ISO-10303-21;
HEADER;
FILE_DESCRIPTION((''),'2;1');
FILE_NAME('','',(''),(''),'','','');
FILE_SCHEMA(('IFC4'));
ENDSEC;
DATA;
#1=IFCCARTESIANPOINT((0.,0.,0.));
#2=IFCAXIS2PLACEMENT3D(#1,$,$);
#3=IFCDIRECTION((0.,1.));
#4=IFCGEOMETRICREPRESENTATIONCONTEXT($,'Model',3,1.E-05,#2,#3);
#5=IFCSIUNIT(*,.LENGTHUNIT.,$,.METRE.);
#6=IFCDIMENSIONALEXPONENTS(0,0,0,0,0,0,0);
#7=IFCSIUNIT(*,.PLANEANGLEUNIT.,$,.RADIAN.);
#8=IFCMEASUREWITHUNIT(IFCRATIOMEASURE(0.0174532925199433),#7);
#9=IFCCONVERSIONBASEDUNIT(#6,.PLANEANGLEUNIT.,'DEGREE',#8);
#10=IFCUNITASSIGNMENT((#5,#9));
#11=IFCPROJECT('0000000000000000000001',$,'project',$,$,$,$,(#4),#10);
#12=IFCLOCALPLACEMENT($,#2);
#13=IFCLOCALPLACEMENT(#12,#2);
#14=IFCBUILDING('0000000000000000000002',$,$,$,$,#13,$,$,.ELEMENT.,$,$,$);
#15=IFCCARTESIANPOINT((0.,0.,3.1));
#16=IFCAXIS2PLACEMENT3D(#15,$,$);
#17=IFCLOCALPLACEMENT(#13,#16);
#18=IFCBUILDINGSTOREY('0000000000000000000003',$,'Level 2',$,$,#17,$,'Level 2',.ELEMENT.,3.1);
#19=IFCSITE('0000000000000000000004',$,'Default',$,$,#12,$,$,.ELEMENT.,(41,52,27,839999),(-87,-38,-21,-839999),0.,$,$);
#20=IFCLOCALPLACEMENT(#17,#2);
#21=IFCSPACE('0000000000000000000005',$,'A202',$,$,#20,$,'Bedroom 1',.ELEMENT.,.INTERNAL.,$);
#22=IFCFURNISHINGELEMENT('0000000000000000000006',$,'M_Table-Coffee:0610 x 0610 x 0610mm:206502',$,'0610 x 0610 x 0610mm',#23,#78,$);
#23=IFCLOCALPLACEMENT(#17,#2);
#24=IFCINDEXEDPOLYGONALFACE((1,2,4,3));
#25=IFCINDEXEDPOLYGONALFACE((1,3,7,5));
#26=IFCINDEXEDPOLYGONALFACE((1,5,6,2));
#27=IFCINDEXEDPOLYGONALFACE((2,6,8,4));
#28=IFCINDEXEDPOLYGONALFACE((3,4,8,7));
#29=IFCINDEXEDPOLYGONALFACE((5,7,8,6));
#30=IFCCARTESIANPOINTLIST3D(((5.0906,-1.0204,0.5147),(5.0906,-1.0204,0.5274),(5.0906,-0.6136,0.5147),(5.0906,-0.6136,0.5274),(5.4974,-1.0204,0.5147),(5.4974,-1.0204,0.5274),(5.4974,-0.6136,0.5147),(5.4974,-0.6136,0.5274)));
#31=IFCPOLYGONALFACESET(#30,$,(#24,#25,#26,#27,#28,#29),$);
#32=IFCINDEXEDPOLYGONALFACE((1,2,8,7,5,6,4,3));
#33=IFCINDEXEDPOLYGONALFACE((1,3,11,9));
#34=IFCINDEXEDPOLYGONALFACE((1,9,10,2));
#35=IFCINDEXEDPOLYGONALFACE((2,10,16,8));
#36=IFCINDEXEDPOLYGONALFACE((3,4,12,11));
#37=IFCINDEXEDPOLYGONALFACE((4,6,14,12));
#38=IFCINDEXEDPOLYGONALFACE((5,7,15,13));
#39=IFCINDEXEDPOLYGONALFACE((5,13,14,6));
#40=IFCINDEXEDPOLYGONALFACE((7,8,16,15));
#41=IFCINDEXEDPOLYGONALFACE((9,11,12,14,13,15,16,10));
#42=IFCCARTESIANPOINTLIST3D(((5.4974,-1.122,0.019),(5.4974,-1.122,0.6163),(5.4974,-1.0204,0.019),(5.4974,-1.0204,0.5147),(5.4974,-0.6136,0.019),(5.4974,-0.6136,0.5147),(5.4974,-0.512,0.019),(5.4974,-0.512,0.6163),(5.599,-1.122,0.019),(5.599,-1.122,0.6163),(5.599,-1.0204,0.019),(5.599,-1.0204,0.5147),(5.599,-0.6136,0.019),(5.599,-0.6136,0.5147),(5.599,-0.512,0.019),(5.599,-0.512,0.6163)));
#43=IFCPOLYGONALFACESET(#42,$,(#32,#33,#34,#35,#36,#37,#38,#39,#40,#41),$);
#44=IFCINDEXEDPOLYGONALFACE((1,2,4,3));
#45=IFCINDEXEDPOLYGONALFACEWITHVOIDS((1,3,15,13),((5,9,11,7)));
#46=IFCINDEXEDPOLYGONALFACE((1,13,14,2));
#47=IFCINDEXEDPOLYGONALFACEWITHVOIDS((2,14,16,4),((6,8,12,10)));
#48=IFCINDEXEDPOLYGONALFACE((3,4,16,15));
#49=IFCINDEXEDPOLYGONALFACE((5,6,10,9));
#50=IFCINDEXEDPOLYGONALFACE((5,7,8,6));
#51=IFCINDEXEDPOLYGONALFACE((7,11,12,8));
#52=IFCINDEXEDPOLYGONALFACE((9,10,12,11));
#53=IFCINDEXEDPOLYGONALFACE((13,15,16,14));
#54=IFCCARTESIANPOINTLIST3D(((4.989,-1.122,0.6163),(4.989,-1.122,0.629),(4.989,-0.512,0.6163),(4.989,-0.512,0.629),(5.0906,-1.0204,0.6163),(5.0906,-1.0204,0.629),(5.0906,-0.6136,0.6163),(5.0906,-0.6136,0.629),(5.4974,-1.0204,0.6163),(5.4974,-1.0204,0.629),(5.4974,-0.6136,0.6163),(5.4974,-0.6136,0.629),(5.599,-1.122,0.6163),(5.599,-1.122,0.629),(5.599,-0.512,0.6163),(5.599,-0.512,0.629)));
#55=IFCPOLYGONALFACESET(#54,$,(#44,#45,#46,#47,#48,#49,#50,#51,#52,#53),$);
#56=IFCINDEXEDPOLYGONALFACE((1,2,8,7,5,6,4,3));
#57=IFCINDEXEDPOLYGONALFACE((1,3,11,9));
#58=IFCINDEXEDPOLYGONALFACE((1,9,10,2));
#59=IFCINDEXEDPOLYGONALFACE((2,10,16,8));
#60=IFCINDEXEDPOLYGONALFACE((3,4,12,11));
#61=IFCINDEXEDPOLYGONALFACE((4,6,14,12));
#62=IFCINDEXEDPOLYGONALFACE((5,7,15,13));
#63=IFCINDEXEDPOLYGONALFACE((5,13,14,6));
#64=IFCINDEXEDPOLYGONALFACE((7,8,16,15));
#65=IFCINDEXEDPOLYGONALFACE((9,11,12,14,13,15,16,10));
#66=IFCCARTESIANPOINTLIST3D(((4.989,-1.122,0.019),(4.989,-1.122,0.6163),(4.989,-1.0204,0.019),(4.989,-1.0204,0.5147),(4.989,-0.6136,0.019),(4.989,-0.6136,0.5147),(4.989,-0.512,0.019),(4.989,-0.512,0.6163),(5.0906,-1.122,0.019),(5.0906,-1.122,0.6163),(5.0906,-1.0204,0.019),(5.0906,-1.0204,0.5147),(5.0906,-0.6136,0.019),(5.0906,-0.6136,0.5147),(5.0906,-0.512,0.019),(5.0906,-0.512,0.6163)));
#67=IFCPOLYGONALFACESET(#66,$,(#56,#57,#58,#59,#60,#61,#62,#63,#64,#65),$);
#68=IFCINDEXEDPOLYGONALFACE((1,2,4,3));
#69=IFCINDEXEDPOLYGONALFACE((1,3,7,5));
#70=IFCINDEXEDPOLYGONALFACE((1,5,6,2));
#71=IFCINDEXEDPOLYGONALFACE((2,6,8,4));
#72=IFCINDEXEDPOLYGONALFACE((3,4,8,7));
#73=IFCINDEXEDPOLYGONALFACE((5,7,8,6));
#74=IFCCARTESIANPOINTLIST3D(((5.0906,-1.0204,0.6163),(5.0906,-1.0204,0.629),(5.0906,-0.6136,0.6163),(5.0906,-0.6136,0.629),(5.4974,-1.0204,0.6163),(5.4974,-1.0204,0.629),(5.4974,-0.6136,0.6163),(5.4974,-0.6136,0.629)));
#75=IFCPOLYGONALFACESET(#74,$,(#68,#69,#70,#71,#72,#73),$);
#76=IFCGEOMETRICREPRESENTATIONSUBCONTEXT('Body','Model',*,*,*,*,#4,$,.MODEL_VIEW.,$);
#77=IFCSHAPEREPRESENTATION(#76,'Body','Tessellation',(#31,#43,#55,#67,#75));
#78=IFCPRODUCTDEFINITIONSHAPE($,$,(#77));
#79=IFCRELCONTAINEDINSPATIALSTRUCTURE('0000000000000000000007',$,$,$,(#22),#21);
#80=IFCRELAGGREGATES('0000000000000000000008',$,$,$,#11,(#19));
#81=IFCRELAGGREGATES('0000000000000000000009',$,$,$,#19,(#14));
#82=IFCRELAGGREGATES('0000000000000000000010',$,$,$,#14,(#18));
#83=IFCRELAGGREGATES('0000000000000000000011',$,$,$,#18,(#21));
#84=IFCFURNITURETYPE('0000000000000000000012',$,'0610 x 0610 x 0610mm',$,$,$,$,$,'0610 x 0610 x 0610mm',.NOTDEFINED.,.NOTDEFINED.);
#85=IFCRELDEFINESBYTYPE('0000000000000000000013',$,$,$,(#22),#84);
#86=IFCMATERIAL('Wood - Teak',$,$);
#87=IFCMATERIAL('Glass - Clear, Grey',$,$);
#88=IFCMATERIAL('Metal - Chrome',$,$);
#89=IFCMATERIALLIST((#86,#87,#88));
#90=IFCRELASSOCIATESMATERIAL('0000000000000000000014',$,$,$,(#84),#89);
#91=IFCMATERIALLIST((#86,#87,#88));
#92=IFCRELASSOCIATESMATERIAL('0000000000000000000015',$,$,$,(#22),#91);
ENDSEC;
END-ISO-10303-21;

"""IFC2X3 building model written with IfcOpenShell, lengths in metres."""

from ifc_helpers import new_model, entity, si_unit, converted_unit, direction, frame, origin, origin_2d_with_axis, place, context, subcontext, project, spatial, polyline, rectangle, outline, extrude, source, transform, mapped, material, material_list, type_object, type_shapes, element, save


model = new_model("IFC2X3")

# Units and contexts
model_context = context("Model", 3, precision=1e-05, world=origin(), true_north=direction((0.0, 1.0)))
body_context = subcontext(model_context, "Body", "Model", "MODEL_VIEW")
ifc_project = project(units=[si_unit("LENGTHUNIT", "METRE"), converted_unit("PLANEANGLEUNIT", "DEGREE", entity("IfcRatioMeasure", 0.0174532925199433), si_unit("PLANEANGLEUNIT", "RADIAN"), dimensions=[0, 0, 0, 0, 0, 0, 0])], contexts=[model_context])

# Site, building, storey
site_placement = place(None, origin())
site = spatial("IfcSite", under=ifc_project, at=site_placement, Name="Default", CompositionType="ELEMENT", RefLatitude=(41, 52, 27, 839999), RefLongitude=(-87, -38, -21, -839999), RefElevation=0.0)
building_placement = place(site_placement, origin())
building = spatial("IfcBuilding", under=site, at=building_placement, CompositionType="ELEMENT")
storey_placement = place(building_placement, frame((0.0, 0.0, 3.1)))
storey = spatial("IfcBuildingStorey", under=building, at=storey_placement, Name="Level 2", LongName="Level 2", CompositionType="ELEMENT", Elevation=3.1)

# Shared definitions
ifc_material_1 = material(Name="Wood - Teak")
ifc_material_2 = material(Name="Glass - Clear, Grey")
ifc_material_3 = material(Name="Metal - Chrome")
ifc_material_list_1 = material_list([ifc_material_1, ifc_material_2, ifc_material_3])
furniture_type_1 = type_object("IfcFurnitureType", Name="0610 x 0610 x 0610mm", ElementType="0610 x 0610 x 0610mm", AssemblyPlace="NOTDEFINED", material=ifc_material_list_1)
shared_shape_1 = source(origin(), body_context, "Body", "SweptSolid", [
    extrude(rectangle(XDim=0.4068, YDim=0.4068, at=origin_2d_with_axis()), frame((0.0183, 0.0952, 0.4957), z_axis=(0.0, 0.0, 1.0), x_axis=(-1.0, 0.0, 0.0)), (0.0, 0.0, 1.0), 0.0127),
    extrude(outline(polyline([(-0.2732, -0.305), (0.324, -0.305), (0.324, 0.305), (-0.2732, 0.305), (-0.2732, 0.2034), (0.2225, 0.2034), (0.2225, -0.2034), (-0.2732, -0.2034), (-0.2732, -0.305)])), frame((0.2217, 0.0952, 0.2732), z_axis=(1.0, 0.0, 0.0), x_axis=(0.0, 0.0, 1.0)), (0.0, 0.0, 1.0), 0.1016),
    extrude(outline(polyline([(-0.305, -0.305), (0.305, -0.305), (0.305, 0.305), (-0.305, 0.305), (-0.305, -0.305)]), holes=[polyline([(-0.2034, -0.2034), (-0.2034, 0.2034), (0.2034, 0.2034), (0.2034, -0.2034), (-0.2034, -0.2034)])]), frame((0.0183, 0.0952, 0.5973), z_axis=(0.0, 0.0, 1.0), x_axis=(-1.0, 0.0, 0.0)), (0.0, 0.0, 1.0), 0.0127),
    extrude(outline(polyline([(-0.305, -0.3241), (0.305, -0.3241), (0.305, 0.2733), (0.2034, 0.2733), (0.2034, -0.2224), (-0.2034, -0.2224), (-0.2034, 0.2733), (-0.305, 0.2733), (-0.305, -0.3241)])), frame((-0.2867, 0.0952, 0.2733), z_axis=(1.0, 0.0, 0.0), x_axis=(0.0, -1.0, 0.0)), (0.0, 0.0, 1.0), 0.1016),
    extrude(rectangle(XDim=0.4068, YDim=0.4068, at=origin_2d_with_axis()), frame((0.0183, 0.0952, 0.5973), z_axis=(0.0, 0.0, 1.0), x_axis=(-1.0, 0.0, 0.0)), (0.0, 0.0, 1.0), 0.0127),
])
type_shapes(furniture_type_1, [shared_shape_1])

# Shared definitions
space_1_placement = place(storey_placement, origin())
space_1 = spatial("IfcSpace", under=storey, at=space_1_placement, Name="A202", LongName="Bedroom 1", CompositionType="ELEMENT", InteriorOrExteriorSpace="INTERNAL")

# Furnishing element
ifc_material_list_2 = material_list([ifc_material_1, ifc_material_2, ifc_material_3])
furnishing_1_placement = place(space_1_placement, frame((5.2757, -0.9122, 0.019)))
element("IfcFurnishingElement", 1, at=furnishing_1_placement, inside=space_1, type_object=furniture_type_1, material=ifc_material_list_2, Name="M_Table-Coffee:0610 x 0610 x 0610mm:206502", ObjectType="0610 x 0610 x 0610mm", context=body_context, shape_type="MappedRepresentation", body=[
    mapped(shared_shape_1, transform((0.0, 0.0, 0.0), scale=1.0)),
])

save(model, "model.ifc")
